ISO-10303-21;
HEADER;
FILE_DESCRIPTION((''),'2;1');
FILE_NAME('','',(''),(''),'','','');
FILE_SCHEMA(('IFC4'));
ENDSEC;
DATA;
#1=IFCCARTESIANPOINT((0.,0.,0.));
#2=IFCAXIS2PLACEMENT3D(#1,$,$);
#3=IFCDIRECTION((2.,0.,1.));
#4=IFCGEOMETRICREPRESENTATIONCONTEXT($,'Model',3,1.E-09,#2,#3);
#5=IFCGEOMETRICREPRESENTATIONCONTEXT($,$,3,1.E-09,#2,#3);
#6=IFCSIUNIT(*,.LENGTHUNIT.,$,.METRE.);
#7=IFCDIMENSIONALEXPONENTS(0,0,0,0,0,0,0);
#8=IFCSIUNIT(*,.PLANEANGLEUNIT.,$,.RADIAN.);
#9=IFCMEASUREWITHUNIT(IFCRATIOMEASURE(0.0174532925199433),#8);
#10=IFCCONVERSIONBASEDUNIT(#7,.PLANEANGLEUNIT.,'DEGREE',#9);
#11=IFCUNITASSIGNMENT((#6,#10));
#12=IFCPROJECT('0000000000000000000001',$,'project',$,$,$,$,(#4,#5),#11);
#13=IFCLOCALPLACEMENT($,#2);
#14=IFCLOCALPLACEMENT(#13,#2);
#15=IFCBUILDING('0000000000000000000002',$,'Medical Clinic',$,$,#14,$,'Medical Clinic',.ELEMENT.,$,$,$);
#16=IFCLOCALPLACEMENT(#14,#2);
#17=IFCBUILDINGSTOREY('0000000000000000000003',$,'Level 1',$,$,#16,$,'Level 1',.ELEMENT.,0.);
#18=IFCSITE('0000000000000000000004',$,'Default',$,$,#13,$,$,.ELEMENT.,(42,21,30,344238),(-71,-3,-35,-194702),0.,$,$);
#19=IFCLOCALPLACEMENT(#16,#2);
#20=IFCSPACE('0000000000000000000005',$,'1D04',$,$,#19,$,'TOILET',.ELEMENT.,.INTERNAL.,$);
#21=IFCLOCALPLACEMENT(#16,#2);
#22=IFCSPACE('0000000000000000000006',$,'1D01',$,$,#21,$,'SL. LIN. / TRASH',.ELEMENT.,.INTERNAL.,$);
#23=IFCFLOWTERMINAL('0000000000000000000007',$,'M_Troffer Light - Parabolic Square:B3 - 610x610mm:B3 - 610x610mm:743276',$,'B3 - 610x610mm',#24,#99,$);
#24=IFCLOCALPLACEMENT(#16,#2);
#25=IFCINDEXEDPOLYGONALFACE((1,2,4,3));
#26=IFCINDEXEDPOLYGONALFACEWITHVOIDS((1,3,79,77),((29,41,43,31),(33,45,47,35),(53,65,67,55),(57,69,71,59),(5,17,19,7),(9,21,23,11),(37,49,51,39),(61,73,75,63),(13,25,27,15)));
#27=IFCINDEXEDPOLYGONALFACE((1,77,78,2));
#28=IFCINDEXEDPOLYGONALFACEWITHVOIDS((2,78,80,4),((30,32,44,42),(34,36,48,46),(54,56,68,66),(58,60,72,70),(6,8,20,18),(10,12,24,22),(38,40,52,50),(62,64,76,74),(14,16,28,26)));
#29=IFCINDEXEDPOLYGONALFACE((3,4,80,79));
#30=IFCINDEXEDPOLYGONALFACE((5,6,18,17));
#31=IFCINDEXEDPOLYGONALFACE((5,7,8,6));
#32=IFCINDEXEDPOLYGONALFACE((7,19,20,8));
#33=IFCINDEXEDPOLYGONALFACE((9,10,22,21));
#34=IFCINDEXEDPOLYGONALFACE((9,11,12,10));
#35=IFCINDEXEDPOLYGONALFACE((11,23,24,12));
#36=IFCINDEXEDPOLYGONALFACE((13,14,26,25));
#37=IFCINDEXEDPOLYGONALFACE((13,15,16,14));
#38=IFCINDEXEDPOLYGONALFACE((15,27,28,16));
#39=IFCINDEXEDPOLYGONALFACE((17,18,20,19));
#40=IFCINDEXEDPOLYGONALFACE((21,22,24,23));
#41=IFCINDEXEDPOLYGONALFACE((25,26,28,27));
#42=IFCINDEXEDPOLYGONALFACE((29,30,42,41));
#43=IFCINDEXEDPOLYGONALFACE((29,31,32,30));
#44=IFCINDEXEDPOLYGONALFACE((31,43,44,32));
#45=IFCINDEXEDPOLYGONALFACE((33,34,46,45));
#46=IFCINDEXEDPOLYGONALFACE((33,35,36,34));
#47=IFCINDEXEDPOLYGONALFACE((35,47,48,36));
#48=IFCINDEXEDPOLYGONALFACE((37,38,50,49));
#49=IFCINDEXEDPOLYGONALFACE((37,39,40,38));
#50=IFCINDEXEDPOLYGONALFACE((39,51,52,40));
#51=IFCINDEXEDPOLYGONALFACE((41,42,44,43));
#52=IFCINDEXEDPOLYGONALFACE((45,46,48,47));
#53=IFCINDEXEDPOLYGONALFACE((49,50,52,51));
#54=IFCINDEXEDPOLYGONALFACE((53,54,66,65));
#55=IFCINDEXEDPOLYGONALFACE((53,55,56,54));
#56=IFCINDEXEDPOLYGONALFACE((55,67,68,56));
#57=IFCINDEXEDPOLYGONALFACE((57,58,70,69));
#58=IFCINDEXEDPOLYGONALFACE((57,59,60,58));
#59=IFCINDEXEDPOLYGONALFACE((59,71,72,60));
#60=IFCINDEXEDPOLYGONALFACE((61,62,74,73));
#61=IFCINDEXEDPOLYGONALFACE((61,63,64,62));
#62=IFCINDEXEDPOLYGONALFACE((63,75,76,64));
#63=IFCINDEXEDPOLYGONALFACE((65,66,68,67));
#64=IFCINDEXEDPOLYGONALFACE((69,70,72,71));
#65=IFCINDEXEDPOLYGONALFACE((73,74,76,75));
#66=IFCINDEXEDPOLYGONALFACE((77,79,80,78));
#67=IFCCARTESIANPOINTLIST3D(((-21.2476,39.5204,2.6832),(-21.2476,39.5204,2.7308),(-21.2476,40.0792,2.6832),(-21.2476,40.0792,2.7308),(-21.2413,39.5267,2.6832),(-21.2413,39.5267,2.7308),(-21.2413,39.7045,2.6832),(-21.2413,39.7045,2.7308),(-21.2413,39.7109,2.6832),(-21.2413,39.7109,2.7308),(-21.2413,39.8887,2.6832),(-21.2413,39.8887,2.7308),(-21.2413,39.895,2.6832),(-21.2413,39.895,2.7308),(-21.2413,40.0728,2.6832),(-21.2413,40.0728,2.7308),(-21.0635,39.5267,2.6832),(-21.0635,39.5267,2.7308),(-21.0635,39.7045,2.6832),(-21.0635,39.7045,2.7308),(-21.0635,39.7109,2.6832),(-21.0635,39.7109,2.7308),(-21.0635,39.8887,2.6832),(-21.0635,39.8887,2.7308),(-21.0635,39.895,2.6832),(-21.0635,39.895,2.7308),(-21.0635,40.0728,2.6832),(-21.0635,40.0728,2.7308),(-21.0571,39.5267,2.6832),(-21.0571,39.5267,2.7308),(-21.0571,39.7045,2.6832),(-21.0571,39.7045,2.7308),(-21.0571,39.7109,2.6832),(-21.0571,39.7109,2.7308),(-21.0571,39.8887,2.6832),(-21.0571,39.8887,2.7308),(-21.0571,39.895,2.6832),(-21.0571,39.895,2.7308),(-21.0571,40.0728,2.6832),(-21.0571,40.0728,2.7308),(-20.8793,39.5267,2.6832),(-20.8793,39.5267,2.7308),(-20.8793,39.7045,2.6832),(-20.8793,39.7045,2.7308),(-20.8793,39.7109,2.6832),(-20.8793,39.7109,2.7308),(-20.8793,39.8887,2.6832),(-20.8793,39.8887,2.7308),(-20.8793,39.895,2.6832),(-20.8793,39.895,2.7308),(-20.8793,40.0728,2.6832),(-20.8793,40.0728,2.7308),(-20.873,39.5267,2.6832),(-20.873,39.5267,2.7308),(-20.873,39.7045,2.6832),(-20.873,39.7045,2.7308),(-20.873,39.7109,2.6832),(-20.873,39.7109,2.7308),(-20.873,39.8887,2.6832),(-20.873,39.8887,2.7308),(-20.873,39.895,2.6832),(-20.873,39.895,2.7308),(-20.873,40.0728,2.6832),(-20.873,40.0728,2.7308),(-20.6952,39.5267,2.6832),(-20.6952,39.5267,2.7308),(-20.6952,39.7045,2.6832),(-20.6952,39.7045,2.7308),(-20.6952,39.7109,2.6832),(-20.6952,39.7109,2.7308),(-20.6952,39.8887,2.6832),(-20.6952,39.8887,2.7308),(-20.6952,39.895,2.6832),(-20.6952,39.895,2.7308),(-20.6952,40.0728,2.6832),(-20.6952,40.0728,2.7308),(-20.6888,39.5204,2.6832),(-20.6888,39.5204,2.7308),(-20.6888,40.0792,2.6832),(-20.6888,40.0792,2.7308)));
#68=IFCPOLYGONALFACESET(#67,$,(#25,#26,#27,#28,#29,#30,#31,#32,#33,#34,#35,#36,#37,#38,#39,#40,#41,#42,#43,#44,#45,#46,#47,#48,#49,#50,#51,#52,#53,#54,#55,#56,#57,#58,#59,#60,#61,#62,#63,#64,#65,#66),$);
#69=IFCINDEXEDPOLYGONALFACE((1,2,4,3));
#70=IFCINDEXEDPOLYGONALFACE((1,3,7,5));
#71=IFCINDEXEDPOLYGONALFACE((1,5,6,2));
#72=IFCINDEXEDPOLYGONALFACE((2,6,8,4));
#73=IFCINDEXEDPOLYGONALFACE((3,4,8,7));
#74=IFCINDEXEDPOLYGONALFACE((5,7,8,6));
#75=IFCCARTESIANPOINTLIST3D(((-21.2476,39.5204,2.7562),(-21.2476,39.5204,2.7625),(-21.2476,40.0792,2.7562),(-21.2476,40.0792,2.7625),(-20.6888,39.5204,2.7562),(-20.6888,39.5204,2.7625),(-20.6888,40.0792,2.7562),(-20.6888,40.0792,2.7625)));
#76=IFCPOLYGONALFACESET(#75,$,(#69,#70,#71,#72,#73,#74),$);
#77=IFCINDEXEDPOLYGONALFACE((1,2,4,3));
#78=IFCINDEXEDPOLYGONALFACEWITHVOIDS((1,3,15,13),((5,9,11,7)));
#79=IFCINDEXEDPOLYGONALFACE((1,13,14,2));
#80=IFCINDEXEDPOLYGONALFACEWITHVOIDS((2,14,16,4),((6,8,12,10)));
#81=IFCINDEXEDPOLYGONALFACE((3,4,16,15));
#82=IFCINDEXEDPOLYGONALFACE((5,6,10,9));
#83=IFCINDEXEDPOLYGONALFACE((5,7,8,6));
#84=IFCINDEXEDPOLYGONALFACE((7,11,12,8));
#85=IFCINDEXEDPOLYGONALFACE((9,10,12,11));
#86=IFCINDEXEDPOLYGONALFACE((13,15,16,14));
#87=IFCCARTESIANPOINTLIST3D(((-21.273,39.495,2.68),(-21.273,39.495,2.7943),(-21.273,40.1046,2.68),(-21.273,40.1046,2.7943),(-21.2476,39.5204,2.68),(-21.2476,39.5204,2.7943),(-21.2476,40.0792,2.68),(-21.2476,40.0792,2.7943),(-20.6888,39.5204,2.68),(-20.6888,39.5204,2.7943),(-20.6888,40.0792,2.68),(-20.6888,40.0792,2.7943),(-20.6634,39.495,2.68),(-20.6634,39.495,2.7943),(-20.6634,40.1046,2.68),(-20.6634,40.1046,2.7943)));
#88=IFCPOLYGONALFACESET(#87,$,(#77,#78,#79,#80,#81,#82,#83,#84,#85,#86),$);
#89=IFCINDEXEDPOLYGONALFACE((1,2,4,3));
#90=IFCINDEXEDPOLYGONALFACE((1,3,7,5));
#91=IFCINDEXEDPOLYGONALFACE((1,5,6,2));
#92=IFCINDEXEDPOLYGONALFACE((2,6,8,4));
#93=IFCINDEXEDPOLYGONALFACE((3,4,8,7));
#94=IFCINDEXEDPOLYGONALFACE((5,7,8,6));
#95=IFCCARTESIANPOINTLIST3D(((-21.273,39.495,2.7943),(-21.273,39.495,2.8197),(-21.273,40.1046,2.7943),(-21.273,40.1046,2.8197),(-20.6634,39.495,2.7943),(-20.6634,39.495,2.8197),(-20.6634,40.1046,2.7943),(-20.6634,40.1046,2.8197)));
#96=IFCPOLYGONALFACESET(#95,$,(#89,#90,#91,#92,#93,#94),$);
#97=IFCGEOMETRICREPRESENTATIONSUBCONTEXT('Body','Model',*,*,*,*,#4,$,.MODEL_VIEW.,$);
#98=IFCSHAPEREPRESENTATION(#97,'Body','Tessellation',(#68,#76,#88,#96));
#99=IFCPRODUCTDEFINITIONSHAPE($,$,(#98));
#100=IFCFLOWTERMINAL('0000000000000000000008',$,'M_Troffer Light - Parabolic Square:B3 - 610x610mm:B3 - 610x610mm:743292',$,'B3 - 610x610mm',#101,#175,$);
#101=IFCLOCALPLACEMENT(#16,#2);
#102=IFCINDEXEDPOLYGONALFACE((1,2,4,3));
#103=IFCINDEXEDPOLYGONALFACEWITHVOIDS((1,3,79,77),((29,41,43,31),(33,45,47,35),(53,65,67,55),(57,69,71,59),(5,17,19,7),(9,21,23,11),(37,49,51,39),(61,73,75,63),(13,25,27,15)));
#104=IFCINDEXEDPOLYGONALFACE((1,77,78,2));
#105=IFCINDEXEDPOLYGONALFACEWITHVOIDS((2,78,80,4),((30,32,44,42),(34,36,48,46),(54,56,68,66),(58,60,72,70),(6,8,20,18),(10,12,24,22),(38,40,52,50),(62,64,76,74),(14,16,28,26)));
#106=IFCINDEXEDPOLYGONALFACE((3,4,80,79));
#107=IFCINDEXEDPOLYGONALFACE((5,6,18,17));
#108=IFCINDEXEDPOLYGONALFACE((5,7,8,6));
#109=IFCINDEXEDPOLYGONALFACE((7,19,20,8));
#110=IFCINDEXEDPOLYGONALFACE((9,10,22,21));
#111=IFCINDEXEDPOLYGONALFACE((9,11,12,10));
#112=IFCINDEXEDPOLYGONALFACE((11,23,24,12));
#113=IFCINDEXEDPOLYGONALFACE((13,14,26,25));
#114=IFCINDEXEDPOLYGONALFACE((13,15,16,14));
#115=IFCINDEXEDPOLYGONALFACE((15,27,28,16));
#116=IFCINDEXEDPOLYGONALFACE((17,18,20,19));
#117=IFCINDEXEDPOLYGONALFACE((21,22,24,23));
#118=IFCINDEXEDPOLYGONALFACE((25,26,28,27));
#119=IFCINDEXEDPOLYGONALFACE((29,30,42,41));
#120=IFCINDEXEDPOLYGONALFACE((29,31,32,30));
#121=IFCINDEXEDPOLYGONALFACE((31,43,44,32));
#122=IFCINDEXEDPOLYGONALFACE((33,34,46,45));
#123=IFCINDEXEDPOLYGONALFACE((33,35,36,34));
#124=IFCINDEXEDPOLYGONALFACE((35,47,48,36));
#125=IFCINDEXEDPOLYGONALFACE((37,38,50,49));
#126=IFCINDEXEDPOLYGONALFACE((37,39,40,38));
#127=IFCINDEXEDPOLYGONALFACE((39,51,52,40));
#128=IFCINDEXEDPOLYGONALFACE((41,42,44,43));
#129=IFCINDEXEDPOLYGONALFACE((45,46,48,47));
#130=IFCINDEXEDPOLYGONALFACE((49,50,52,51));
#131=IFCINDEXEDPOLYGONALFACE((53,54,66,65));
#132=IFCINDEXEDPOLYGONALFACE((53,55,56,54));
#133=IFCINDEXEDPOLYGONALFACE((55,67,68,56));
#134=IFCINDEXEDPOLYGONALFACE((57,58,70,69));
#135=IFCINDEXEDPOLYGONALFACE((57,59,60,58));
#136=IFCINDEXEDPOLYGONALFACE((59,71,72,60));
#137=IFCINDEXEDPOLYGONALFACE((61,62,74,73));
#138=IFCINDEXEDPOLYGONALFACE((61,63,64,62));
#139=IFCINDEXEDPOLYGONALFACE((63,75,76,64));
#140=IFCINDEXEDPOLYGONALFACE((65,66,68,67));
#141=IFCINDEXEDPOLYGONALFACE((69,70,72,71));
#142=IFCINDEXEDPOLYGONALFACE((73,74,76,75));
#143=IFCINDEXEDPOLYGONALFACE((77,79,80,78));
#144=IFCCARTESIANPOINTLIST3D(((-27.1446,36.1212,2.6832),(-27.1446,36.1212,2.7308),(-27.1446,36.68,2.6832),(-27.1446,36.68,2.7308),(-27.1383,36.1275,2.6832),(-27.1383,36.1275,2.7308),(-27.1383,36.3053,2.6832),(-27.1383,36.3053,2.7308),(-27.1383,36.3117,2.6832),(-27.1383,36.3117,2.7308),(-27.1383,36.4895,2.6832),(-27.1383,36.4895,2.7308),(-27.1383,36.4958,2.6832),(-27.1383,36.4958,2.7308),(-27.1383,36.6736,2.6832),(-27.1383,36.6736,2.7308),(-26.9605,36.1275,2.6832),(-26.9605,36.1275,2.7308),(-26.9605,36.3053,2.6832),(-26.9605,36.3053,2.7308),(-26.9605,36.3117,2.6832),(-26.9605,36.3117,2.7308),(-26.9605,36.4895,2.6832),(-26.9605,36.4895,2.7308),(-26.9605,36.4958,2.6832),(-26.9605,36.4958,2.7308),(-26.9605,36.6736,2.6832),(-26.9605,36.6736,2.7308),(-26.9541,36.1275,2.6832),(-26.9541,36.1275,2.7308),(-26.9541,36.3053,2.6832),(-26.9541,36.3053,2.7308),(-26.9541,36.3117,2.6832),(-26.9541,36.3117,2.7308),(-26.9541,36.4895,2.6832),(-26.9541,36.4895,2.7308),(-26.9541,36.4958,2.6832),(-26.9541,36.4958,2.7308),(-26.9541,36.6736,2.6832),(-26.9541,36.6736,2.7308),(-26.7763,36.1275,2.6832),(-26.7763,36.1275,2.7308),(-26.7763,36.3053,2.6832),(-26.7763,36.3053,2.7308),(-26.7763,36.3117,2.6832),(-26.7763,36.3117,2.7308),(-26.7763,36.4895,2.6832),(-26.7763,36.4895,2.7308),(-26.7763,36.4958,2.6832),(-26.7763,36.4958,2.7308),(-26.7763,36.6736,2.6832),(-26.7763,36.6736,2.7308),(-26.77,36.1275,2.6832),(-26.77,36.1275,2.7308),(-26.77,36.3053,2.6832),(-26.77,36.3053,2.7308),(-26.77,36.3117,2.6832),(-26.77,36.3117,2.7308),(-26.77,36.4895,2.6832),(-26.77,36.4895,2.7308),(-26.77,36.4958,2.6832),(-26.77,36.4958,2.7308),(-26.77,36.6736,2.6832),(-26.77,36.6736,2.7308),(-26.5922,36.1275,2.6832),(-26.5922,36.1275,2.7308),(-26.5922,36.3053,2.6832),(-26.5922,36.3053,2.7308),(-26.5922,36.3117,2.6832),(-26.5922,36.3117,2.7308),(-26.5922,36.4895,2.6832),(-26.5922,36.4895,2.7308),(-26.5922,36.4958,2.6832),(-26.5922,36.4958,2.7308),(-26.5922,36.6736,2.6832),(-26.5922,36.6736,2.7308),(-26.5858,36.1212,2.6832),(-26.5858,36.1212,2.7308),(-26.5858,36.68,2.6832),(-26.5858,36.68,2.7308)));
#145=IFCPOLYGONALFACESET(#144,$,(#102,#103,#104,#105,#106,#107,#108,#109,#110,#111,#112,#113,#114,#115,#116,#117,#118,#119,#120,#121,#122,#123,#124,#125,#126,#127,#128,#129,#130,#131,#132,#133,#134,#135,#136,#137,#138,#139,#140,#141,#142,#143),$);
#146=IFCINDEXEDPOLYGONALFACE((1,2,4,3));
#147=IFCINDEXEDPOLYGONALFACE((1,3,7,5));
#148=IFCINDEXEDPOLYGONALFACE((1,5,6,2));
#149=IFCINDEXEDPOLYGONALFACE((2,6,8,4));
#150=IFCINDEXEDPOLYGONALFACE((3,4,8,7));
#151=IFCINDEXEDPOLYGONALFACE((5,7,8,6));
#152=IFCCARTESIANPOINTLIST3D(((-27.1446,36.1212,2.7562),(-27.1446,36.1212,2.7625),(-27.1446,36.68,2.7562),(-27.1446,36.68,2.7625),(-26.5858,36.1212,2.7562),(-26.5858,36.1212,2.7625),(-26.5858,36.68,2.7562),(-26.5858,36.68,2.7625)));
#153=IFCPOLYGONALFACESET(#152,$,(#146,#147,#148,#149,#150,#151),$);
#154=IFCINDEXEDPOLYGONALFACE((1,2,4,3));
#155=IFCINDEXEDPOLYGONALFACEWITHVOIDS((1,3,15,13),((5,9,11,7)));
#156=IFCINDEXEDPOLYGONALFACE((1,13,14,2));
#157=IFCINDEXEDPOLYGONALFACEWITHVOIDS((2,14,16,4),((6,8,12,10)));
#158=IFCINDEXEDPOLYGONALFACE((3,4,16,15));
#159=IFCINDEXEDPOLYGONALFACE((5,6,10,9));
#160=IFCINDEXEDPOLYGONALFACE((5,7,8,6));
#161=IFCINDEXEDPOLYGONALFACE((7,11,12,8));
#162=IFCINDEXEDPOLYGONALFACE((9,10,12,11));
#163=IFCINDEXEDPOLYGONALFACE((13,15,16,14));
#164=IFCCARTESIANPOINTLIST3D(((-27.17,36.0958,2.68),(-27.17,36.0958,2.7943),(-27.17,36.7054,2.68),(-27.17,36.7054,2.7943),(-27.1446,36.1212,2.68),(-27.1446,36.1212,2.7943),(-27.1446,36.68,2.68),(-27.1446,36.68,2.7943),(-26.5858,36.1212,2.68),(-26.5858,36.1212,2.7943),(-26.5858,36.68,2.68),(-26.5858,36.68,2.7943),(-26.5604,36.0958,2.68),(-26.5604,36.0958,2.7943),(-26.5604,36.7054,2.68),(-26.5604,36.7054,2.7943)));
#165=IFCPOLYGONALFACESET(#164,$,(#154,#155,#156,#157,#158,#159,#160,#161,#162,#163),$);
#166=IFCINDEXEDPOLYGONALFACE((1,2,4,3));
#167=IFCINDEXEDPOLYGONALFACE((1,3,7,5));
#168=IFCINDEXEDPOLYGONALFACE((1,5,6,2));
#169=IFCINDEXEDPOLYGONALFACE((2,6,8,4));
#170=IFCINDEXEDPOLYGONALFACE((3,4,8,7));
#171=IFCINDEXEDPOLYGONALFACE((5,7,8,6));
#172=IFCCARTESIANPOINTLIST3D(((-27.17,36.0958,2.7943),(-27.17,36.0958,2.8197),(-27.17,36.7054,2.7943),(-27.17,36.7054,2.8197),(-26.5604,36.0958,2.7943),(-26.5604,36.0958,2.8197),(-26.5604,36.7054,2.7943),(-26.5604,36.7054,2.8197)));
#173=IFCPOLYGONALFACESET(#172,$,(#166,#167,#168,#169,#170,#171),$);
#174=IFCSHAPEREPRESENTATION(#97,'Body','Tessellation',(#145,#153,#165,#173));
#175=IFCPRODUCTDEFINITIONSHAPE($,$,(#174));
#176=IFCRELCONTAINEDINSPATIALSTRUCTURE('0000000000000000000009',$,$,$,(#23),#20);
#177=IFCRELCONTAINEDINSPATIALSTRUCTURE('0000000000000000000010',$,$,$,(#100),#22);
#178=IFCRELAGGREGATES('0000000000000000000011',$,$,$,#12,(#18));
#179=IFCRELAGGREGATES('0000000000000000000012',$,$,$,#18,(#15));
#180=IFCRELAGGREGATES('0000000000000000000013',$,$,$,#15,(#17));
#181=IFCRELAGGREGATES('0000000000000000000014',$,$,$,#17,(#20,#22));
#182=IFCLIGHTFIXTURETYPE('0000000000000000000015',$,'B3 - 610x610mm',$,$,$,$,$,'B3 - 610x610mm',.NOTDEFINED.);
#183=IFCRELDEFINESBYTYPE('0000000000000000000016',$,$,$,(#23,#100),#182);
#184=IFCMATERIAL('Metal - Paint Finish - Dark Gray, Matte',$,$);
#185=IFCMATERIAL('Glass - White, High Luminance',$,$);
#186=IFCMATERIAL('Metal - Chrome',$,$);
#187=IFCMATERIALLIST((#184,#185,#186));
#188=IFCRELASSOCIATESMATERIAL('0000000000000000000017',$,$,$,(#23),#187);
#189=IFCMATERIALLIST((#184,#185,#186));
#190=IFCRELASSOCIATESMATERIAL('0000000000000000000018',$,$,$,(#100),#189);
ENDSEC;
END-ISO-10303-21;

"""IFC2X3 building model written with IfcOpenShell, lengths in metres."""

from ifc_helpers import new_model, entity, si_unit, converted_unit, direction, frame, origin, origin_2d_with_axis, place, context, subcontext, project, spatial, polyline, rectangle, outline, extrude, source, transform, mapped, material, material_list, type_object, type_shapes, element, save


model = new_model("IFC2X3")

# Units and contexts
model_context = context("Model", 3, precision=1e-09, world=origin(), true_north=direction((2.0, 0.0, 1.0)))
context_of_model = context(None, 3, precision=1e-09, world=origin(), true_north=direction((2.0, 0.0, 1.0)))
body_context = subcontext(model_context, "Body", "Model", "MODEL_VIEW")
ifc_project = project(units=[si_unit("LENGTHUNIT", "METRE"), converted_unit("PLANEANGLEUNIT", "DEGREE", entity("IfcRatioMeasure", 0.0174532925199433), si_unit("PLANEANGLEUNIT", "RADIAN"), dimensions=[0, 0, 0, 0, 0, 0, 0])], contexts=[model_context, context_of_model])

# Site, building, storey, space
site_placement = place(None, origin())
site = spatial("IfcSite", under=ifc_project, at=site_placement, Name="Default", CompositionType="ELEMENT", RefLatitude=(42, 21, 30, 344238), RefLongitude=(-71, -3, -35, -194702), RefElevation=0.0)
building_placement = place(site_placement, origin())
building = spatial("IfcBuilding", under=site, at=building_placement, Name="Medical Clinic", LongName="Medical Clinic", CompositionType="ELEMENT")
storey_placement = place(building_placement, origin())
storey = spatial("IfcBuildingStorey", under=building, at=storey_placement, Name="Level 1", LongName="Level 1", CompositionType="ELEMENT", Elevation=0.0)
space_1_placement = place(storey_placement, origin())
space_1 = spatial("IfcSpace", under=storey, at=space_1_placement, Name="1D04", LongName="TOILET", CompositionType="ELEMENT", InteriorOrExteriorSpace="INTERNAL")

# Flow terminal
ifc_material_1 = material(Name="Metal - Paint Finish - Dark Gray, Matte")
ifc_material_2 = material(Name="Glass - White, High Luminance")
ifc_material_3 = material(Name="Metal - Chrome")
ifc_material_list_1 = material_list([ifc_material_1, ifc_material_2, ifc_material_3])
light_fixture_type_1 = type_object("IfcLightFixtureType", Name="B3 - 610x610mm", ElementType="B3 - 610x610mm", PredefinedType="NOTDEFINED")
shared_shape_1 = source(origin(), body_context, "Body", "SweptSolid", [
    extrude(outline(polyline([(-0.2794, -0.2794), (0.2794, -0.2794), (0.2794, 0.2794), (-0.2794, 0.2794), (-0.2794, -0.2794)]), holes=[polyline([(-0.0952, 0.0953), (-0.273, 0.0953), (-0.273, 0.2731), (-0.0952, 0.2731), (-0.0952, 0.0953)]), polyline([(0.2731, 0.0953), (0.0953, 0.0953), (0.0953, 0.2731), (0.2731, 0.2731), (0.2731, 0.0953)]), polyline([(-0.0889, 0.2731), (0.0889, 0.2731), (0.0889, 0.0953), (-0.0889, 0.0953), (-0.0889, 0.2731)]), polyline([(0.2731, -0.273), (0.0953, -0.273), (0.0953, -0.0952), (0.2731, -0.0952), (0.2731, -0.273)]), polyline([(0.0889, -0.273), (-0.0889, -0.273), (-0.0889, -0.0952), (0.0889, -0.0952), (0.0889, -0.273)]), polyline([(-0.0952, -0.273), (-0.273, -0.273), (-0.273, -0.0952), (-0.0952, -0.0952), (-0.0952, -0.273)]), polyline([(-0.0952, -0.0889), (-0.273, -0.0889), (-0.273, 0.0889), (-0.0952, 0.0889), (-0.0952, -0.0889)]), polyline([(0.0889, -0.0889), (-0.0889, -0.0889), (-0.0889, 0.0889), (0.0889, 0.0889), (0.0889, -0.0889)]), polyline([(0.2731, -0.0889), (0.0953, -0.0889), (0.0953, 0.0889), (0.2731, 0.0889), (0.2731, -0.0889)])]), frame((0.0, -0.3048, -0.0508), z_axis=(0.0, 0.0, 1.0), x_axis=(-1.0, 0.0, 0.0)), (0.0, 0.0, 1.0), 0.0476),
    extrude(rectangle(XDim=0.5588, YDim=0.5588, at=origin_2d_with_axis()), frame((0.0, -0.3048, -0.0825), z_axis=(0.0, 0.0, 1.0), x_axis=(-1.0, 0.0, 0.0)), (0.0, 0.0, 1.0), 0.0064),
    extrude(outline(polyline([(-0.3048, -0.3048), (0.3048, -0.3048), (0.3048, 0.3048), (-0.3048, 0.3048), (-0.3048, -0.3048)]), holes=[polyline([(0.2794, 0.2794), (0.2794, -0.2794), (-0.2794, -0.2794), (-0.2794, 0.2794), (0.2794, 0.2794)])]), frame((0.0, -0.3048, -0.1143)), (0.0, 0.0, 1.0), 0.1143),
    extrude(rectangle(XDim=0.6096, YDim=0.6096, at=origin_2d_with_axis()), frame((0.0, -0.3048, -0.1397), z_axis=(0.0, 0.0, 1.0), x_axis=(-1.0, 0.0, 0.0)), (0.0, 0.0, 1.0), 0.0254),
])
type_shapes(light_fixture_type_1, [shared_shape_1])
flow_terminal_1_placement = place(space_1_placement, frame((-20.9682, 39.495, 2.68), z_axis=(0.0, 0.0, -1.0), x_axis=(1.0, 0.0, 0.0)))
element("IfcFlowTerminal", 1, at=flow_terminal_1_placement, inside=space_1, type_object=light_fixture_type_1, material=ifc_material_list_1, Name="M_Troffer Light - Parabolic Square:B3 - 610x610mm:B3 - 610x610mm:743276", ObjectType="B3 - 610x610mm", context=body_context, shape_type="MappedRepresentation", body=[
    mapped(shared_shape_1, transform((0.0, 0.0, 0.0), scale=1.0)),
])

# Shared definitions
space_2_placement = place(storey_placement, origin())
space_2 = spatial("IfcSpace", under=storey, at=space_2_placement, Name="1D01", LongName="SL. LIN. / TRASH", CompositionType="ELEMENT", InteriorOrExteriorSpace="INTERNAL")

# Flow terminal
ifc_material_list_2 = material_list([ifc_material_1, ifc_material_2, ifc_material_3])
flow_terminal_2_placement = place(space_2_placement, frame((-26.8652, 36.0958, 2.68), z_axis=(0.0, 0.0, -1.0), x_axis=(1.0, 0.0, 0.0)))
element("IfcFlowTerminal", 2, at=flow_terminal_2_placement, inside=space_2, type_object=light_fixture_type_1, material=ifc_material_list_2, Name="M_Troffer Light - Parabolic Square:B3 - 610x610mm:B3 - 610x610mm:743292", ObjectType="B3 - 610x610mm", context=body_context, shape_type="MappedRepresentation", body=[
    mapped(shared_shape_1, transform((0.0, 0.0, 0.0), scale=1.0)),
])

save(model, "model.ifc")
